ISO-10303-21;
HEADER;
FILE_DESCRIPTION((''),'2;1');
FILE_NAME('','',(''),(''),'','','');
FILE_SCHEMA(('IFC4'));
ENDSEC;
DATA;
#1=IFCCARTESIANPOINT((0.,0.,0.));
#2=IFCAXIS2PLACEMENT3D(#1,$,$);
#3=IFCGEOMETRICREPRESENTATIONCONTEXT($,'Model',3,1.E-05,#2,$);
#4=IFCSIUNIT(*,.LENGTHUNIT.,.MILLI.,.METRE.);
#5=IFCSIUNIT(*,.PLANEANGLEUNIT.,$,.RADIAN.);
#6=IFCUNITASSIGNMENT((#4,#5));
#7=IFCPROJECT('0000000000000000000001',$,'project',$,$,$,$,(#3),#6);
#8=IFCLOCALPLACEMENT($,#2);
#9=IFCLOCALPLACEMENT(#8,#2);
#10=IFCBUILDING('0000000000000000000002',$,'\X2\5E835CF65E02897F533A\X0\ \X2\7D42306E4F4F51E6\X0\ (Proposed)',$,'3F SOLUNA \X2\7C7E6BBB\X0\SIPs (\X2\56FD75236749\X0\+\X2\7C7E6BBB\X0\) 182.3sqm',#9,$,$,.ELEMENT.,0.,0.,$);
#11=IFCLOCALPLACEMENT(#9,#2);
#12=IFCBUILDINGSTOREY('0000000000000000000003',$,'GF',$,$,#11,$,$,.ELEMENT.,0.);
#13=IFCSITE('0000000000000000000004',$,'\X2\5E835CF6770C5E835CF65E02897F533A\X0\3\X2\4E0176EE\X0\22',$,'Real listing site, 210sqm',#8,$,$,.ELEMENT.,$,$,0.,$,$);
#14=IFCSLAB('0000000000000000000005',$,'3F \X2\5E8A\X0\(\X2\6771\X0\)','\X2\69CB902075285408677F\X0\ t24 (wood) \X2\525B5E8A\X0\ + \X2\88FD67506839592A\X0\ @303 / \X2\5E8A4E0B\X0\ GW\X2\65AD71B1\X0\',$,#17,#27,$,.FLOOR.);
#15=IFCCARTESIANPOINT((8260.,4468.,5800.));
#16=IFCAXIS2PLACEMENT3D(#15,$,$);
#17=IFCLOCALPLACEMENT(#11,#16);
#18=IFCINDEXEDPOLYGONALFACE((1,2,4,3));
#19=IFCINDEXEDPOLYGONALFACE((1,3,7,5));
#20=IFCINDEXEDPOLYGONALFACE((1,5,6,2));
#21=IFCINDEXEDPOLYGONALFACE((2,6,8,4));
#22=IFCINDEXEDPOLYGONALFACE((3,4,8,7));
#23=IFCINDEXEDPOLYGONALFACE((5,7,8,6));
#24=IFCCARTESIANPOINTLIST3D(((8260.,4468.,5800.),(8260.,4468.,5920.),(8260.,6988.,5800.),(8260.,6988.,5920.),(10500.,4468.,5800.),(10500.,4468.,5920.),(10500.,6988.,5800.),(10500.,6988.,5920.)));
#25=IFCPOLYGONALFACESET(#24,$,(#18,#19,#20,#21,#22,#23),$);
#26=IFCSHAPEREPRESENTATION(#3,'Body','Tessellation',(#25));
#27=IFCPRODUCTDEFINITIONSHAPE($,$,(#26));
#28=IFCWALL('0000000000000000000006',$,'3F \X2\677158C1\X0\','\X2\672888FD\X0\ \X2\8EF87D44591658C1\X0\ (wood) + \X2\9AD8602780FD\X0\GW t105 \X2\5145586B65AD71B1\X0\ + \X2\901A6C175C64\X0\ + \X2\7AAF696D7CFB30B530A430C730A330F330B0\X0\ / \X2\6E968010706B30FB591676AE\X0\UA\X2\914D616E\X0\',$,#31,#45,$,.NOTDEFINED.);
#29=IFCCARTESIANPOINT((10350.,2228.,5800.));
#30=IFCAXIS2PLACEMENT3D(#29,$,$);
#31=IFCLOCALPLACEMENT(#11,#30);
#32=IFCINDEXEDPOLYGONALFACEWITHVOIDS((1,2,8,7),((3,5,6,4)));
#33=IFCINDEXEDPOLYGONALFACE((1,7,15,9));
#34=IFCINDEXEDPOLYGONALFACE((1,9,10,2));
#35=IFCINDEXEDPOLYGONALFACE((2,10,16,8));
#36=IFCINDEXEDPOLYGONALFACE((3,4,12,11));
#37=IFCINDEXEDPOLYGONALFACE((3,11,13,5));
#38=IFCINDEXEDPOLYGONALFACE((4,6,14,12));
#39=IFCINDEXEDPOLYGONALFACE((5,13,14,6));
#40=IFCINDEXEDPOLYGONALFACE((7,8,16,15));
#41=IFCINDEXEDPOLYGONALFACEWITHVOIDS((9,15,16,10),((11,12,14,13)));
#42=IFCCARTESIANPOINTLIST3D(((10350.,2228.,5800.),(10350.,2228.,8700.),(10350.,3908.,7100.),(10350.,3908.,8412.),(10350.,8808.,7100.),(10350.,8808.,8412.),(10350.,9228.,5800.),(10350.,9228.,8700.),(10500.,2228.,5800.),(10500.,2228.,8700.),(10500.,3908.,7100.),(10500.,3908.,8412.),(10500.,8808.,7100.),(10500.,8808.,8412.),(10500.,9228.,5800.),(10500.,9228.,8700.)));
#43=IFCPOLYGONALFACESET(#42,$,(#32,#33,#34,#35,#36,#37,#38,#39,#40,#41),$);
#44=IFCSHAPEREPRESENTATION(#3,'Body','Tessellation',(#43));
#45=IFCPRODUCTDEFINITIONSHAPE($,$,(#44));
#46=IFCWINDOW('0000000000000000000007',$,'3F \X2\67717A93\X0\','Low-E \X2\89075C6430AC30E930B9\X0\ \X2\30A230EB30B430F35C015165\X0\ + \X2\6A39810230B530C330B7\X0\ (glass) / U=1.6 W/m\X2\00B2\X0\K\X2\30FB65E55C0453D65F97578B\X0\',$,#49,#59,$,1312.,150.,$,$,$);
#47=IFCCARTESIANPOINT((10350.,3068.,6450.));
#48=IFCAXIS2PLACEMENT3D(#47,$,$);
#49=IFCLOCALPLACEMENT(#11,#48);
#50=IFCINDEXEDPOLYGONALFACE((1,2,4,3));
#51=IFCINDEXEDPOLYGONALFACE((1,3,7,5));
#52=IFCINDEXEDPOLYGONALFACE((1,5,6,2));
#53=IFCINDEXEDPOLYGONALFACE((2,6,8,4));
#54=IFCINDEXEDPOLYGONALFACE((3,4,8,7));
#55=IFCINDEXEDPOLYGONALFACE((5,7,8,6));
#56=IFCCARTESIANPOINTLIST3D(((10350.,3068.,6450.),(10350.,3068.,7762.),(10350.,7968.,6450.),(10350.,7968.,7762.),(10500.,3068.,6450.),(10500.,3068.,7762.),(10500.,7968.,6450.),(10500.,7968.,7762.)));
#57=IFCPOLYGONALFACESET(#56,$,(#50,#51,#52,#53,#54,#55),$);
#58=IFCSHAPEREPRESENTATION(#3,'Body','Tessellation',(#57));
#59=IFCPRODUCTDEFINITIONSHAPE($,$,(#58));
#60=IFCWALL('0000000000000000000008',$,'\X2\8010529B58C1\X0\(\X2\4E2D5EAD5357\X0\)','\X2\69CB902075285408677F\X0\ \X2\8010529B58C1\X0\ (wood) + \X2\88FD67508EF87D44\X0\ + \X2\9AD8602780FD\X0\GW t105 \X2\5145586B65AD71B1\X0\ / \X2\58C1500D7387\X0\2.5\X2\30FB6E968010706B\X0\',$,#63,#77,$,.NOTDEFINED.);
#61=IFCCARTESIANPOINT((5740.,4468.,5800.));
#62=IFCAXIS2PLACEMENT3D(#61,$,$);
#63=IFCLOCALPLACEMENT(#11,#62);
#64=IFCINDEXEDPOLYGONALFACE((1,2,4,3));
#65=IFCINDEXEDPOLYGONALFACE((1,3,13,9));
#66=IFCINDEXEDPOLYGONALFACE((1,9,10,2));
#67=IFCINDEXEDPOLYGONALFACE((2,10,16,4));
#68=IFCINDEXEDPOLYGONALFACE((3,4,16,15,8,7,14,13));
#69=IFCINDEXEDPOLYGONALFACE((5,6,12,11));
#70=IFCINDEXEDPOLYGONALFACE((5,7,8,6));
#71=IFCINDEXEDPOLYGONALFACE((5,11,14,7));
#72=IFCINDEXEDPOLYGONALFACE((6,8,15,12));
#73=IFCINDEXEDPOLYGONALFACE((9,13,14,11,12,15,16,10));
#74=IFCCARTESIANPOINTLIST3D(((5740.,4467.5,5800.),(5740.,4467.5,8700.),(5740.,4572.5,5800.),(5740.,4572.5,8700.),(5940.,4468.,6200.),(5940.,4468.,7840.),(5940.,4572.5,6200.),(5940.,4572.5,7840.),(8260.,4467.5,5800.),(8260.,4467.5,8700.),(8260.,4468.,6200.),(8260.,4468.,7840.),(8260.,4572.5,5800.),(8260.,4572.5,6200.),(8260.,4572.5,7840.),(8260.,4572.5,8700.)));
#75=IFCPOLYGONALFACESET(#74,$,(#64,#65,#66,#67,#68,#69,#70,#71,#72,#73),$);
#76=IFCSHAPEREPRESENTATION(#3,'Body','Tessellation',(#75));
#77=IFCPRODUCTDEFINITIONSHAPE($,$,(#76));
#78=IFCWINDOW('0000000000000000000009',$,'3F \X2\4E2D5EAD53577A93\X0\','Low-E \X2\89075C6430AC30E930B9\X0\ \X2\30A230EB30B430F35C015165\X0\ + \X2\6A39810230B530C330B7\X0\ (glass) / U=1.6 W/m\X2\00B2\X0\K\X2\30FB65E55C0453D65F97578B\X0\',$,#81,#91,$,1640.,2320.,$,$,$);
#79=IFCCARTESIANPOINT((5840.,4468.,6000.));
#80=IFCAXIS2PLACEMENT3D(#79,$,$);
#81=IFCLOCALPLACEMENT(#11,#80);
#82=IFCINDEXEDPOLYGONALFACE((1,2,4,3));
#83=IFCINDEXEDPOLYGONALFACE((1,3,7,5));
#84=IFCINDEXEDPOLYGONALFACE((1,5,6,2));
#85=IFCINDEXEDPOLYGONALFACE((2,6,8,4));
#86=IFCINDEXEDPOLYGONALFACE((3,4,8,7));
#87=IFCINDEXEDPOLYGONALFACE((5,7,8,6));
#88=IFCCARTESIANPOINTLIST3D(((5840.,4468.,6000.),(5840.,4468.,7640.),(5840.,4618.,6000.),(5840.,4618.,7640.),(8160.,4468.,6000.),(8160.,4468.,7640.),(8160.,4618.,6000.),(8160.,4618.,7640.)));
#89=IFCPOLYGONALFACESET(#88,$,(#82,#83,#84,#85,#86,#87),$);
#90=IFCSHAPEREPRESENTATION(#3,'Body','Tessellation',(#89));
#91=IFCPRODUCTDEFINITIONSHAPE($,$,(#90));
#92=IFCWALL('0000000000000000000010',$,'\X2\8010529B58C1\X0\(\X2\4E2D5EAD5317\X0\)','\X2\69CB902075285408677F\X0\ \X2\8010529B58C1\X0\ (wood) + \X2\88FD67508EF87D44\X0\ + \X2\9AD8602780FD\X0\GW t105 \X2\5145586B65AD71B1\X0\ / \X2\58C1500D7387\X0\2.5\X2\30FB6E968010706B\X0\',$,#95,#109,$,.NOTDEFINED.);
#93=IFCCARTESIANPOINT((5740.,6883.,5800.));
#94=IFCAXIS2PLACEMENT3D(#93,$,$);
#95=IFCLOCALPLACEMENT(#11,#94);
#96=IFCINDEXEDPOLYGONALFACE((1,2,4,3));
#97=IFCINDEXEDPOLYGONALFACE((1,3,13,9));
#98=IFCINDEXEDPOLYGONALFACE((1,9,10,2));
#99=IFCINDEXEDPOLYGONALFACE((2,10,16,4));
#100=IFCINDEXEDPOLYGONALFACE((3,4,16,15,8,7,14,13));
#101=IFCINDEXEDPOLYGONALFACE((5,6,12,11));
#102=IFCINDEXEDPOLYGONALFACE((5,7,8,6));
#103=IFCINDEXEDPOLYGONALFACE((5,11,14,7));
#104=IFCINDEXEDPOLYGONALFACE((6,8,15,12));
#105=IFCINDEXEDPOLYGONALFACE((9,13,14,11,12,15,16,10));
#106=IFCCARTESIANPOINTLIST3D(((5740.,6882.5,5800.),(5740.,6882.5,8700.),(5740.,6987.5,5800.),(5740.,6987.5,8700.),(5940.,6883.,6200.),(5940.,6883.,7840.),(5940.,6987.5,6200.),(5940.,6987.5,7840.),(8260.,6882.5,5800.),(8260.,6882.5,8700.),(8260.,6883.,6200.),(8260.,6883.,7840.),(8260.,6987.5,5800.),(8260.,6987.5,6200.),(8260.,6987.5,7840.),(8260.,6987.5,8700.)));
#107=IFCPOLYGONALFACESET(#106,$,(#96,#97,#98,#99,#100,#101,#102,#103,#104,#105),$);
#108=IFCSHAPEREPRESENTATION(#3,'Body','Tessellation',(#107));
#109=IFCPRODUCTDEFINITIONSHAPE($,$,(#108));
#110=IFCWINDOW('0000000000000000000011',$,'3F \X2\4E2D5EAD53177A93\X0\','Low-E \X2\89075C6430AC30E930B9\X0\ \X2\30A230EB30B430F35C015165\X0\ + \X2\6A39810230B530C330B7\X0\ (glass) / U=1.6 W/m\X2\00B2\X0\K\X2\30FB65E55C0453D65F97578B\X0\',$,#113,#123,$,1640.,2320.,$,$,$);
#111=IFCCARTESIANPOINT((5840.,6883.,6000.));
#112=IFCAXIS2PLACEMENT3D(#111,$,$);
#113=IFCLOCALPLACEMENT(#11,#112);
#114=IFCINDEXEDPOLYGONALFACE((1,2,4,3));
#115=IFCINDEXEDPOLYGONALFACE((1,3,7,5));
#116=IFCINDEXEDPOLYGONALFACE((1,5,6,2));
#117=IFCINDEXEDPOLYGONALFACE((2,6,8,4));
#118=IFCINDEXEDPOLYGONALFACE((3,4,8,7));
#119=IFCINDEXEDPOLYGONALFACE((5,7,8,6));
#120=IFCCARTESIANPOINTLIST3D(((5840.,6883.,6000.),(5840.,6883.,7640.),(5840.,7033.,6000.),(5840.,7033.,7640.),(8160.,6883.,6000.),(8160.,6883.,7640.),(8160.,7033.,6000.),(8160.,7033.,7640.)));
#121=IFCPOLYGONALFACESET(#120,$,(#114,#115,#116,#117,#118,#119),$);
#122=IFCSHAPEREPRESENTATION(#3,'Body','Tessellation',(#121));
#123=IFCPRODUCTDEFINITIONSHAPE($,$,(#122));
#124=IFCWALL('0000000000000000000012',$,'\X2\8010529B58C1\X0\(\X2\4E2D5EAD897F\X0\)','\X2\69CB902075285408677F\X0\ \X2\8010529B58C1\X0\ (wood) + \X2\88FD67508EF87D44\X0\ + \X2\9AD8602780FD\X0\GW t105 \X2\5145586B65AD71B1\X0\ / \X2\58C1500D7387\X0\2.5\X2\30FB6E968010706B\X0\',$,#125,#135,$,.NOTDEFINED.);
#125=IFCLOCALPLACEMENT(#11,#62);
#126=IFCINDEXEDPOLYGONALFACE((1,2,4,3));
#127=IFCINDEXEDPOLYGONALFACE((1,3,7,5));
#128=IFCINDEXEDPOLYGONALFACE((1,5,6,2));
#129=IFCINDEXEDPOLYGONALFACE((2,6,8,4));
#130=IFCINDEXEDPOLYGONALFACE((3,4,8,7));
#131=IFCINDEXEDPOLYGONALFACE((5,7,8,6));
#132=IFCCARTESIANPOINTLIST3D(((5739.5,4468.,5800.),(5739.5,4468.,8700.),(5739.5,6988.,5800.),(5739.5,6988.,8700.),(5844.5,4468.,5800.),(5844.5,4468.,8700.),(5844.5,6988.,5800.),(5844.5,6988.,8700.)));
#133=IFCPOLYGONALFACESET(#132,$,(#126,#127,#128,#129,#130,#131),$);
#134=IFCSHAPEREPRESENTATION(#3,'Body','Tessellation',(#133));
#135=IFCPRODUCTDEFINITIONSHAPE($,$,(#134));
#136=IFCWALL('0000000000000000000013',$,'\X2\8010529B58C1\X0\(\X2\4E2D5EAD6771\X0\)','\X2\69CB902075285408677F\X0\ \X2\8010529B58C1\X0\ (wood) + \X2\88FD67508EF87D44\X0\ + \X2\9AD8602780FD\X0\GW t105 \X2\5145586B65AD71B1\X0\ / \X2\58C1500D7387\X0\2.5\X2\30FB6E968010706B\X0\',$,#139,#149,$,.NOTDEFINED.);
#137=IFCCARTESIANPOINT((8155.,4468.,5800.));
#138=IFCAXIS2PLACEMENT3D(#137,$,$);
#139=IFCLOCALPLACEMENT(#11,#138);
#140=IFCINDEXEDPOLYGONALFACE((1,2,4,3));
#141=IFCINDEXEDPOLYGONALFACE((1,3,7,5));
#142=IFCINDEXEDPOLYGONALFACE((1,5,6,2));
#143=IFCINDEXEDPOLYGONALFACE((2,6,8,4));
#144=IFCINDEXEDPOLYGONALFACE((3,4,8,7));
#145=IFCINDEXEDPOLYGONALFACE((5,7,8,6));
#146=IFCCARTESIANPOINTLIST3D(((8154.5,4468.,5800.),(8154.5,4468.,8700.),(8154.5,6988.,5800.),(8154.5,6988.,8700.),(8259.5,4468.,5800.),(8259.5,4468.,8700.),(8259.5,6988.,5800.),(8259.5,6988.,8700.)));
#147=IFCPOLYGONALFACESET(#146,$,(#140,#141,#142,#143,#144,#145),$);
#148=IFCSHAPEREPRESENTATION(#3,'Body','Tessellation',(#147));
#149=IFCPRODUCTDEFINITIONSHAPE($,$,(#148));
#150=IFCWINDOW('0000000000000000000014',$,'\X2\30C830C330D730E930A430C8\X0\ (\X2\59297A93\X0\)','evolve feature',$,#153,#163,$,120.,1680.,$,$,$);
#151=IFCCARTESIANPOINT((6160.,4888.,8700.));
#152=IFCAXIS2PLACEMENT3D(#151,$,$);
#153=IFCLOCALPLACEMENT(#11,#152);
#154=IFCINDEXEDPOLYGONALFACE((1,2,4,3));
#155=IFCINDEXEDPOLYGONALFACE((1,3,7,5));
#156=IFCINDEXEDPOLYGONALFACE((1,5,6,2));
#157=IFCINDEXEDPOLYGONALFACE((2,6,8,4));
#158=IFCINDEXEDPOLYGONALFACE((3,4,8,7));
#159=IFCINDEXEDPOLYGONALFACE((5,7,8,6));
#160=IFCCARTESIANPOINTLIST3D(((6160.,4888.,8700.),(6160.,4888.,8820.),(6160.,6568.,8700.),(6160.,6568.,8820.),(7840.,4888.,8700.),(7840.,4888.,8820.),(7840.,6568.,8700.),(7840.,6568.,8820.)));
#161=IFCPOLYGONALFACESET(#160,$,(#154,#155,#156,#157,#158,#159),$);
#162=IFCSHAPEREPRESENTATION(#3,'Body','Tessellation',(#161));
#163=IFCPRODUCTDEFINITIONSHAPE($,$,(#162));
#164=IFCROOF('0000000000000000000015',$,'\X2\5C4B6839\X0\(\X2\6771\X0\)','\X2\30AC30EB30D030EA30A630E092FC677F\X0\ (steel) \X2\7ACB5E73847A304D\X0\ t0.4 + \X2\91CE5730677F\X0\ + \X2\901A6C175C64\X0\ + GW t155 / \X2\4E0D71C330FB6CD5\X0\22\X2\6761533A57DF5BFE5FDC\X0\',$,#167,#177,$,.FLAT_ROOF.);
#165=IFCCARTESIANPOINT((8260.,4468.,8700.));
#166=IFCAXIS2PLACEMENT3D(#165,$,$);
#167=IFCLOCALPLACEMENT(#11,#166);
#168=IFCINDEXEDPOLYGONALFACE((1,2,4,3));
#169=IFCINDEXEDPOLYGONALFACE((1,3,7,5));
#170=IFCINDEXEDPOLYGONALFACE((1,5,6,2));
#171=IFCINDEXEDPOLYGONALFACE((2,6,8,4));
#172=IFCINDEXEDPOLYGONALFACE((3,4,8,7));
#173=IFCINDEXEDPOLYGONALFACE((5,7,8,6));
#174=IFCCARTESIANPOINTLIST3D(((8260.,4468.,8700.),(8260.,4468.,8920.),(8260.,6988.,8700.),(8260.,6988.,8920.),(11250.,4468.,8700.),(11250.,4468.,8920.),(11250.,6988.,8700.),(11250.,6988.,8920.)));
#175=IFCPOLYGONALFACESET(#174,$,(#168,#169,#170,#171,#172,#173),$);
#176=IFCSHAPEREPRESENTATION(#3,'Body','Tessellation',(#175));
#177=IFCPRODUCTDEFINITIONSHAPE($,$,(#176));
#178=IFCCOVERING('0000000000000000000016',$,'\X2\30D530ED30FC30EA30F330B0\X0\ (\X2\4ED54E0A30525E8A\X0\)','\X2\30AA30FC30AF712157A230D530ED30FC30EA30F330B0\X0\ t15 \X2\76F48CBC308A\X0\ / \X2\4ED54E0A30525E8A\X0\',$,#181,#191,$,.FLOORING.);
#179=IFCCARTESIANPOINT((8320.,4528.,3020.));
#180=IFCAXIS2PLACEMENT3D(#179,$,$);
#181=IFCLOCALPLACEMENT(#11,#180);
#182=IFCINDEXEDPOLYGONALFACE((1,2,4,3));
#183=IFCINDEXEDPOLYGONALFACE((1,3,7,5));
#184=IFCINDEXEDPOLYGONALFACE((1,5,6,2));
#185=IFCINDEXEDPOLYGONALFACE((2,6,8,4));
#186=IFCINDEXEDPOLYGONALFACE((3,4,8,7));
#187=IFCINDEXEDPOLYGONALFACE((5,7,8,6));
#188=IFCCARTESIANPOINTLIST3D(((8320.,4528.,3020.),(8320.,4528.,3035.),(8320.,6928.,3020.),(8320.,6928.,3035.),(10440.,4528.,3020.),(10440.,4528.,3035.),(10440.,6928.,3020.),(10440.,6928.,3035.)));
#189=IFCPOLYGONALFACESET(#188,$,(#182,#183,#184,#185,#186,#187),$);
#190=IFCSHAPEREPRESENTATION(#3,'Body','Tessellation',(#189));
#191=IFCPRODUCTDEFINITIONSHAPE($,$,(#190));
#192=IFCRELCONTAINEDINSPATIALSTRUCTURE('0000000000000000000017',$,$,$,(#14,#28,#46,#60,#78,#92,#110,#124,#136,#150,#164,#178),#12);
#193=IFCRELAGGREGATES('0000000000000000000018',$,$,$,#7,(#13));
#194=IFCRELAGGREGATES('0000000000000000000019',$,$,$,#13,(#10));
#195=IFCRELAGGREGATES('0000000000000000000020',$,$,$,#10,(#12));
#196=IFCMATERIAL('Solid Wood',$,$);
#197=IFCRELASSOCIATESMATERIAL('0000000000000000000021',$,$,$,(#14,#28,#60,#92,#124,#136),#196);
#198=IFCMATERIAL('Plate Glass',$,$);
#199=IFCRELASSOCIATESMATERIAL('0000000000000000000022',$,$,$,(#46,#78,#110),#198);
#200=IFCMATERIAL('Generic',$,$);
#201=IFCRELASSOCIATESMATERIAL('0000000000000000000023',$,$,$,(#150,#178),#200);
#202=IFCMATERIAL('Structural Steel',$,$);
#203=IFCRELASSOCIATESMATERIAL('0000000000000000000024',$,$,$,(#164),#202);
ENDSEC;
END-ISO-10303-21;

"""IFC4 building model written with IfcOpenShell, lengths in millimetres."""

from ifc_helpers import new_model, si_unit, frame, frame_2d, origin, place, context, project, spatial, rectangle, extrude, material, element, fill, save


model = new_model("IFC4")

# Units and contexts
model_context = context("Model", 3, precision=1e-05, world=origin())
ifc_project = project(units=[si_unit("LENGTHUNIT", "METRE", prefix="MILLI"), si_unit("PLANEANGLEUNIT", "RADIAN")], contexts=[model_context])

# Site, building, storey
site_placement = place(None, origin())
site = spatial("IfcSite", under=ifc_project, at=site_placement, Name="広島県広島市西区3丁目22", ObjectType="Real listing site, 210sqm", CompositionType="ELEMENT", RefElevation=0.0)
building_placement = place(site_placement, origin())
building = spatial("IfcBuilding", under=site, at=building_placement, Name="広島市西区 終の住処 (Proposed)", ObjectType="3F SOLUNA 籾殻SIPs (国産杉+籾殻) 182.3sqm", CompositionType="ELEMENT", ElevationOfRefHeight=0.0, ElevationOfTerrain=0.0)
storey_placement = place(building_placement, origin())
storey = spatial("IfcBuildingStorey", under=building, at=storey_placement, Name="GF", CompositionType="ELEMENT", Elevation=0.0)

# Slab
ifc_material_1 = material(Name="Solid Wood")
slab_placement = place(storey_placement, frame((8260.0, 4468.0, 5800.0)))
element("IfcSlab", 1, at=slab_placement, inside=storey, material=ifc_material_1, Name="3F 床(東)", Description="構造用合板 t24 (wood) 剛床 + 製材根太 @303 / 床下 GW断熱", PredefinedType="FLOOR", context=model_context, shape_type="SweptSolid", body=[
    extrude(rectangle(XDim=2240.0, YDim=2520.0, at=frame_2d((1120.0, 1260.0))), frame((8260.0, 4468.0, 5800.0)), (0.0, 0.0, 1.0), 120.0),
])

# Walls, openings, windows
wall_1_placement = place(storey_placement, frame((10350.0, 2228.0, 5800.0)))
wall_1 = element("IfcWall", 2, at=wall_1_placement, inside=storey, material=ifc_material_1, Name="3F 東壁", Description="木製 軸組外壁 (wood) + 高性能GW t105 充填断熱 + 通気層 + 窯業系サイディング / 準耐火・外皮UA配慮", PredefinedType="NOTDEFINED", context=model_context, shape_type="SweptSolid", body=[
    extrude(rectangle(XDim=150.0, YDim=7000.0, at=frame_2d((75.0, 3500.0))), frame((10350.0, 2228.0, 5800.0)), (0.0, 0.0, 1.0), 2900.0),
])
opening_1_placement = place(storey_placement, frame((10350.0, 3068.0, 6450.0)))
opening_1 = element("IfcOpeningElement", 3, at=opening_1_placement, cuts=wall_1, PredefinedType="NOTDEFINED", context=model_context, shape_type="SweptSolid", body=[
    extrude(rectangle(XDim=150.0, YDim=4900.0, at=frame_2d((75.0, 2450.0))), frame((10350.0, 3068.0, 6450.0)), (0.0, 0.0, 1.0), 1312.0),
])
ifc_material_2 = material(Name="Plate Glass")
window_1_placement = place(storey_placement, frame((10350.0, 3068.0, 6450.0)))
window_1 = element("IfcWindow", 4, at=window_1_placement, inside=storey, material=ifc_material_2, Name="3F 東窓", Description="Low-E 複層ガラス アルゴン封入 + 樹脂サッシ (glass) / U=1.6 W/m²K・日射取得型", OverallHeight=1312.0, OverallWidth=150.0, context=model_context, shape_type="SweptSolid", body=[
    extrude(rectangle(XDim=150.0, YDim=4900.0, at=frame_2d((75.0, 2450.0))), frame((10350.0, 3068.0, 6450.0)), (0.0, 0.0, 1.0), 1312.0),
])
fill(opening_1, window_1)
wall_2_placement = place(storey_placement, frame((5740.0, 4468.0, 5800.0)))
wall_2 = element("IfcWall", 5, at=wall_2_placement, inside=storey, material=ifc_material_1, Name="耐力壁(中庭南)", Description="構造用合板 耐力壁 (wood) + 製材軸組 + 高性能GW t105 充填断熱 / 壁倍率2.5・準耐火", PredefinedType="NOTDEFINED", context=model_context, shape_type="SweptSolid", body=[
    extrude(rectangle(XDim=2520.0, YDim=105.0, at=frame_2d((1260.0, 52.0))), frame((5740.0, 4468.0, 5800.0)), (0.0, 0.0, 1.0), 2900.0),
])
opening_2_placement = place(storey_placement, frame((5840.0, 4468.0, 6000.0)))
opening_2 = element("IfcOpeningElement", 6, at=opening_2_placement, cuts=wall_2, PredefinedType="NOTDEFINED", context=model_context, shape_type="SweptSolid", body=[
    extrude(rectangle(XDim=2320.0, YDim=150.0, at=frame_2d((1160.0, 75.0))), frame((5840.0, 4468.0, 6000.0)), (0.0, 0.0, 1.0), 1640.0),
])
window_2_placement = place(storey_placement, frame((5840.0, 4468.0, 6000.0)))
window_2 = element("IfcWindow", 7, at=window_2_placement, inside=storey, material=ifc_material_2, Name="3F 中庭南窓", Description="Low-E 複層ガラス アルゴン封入 + 樹脂サッシ (glass) / U=1.6 W/m²K・日射取得型", OverallHeight=1640.0, OverallWidth=2320.0, context=model_context, shape_type="SweptSolid", body=[
    extrude(rectangle(XDim=2320.0, YDim=150.0, at=frame_2d((1160.0, 75.0))), frame((5840.0, 4468.0, 6000.0)), (0.0, 0.0, 1.0), 1640.0),
])
fill(opening_2, window_2)
wall_3_placement = place(storey_placement, frame((5740.0, 6883.0, 5800.0)))
wall_3 = element("IfcWall", 8, at=wall_3_placement, inside=storey, material=ifc_material_1, Name="耐力壁(中庭北)", Description="構造用合板 耐力壁 (wood) + 製材軸組 + 高性能GW t105 充填断熱 / 壁倍率2.5・準耐火", PredefinedType="NOTDEFINED", context=model_context, shape_type="SweptSolid", body=[
    extrude(rectangle(XDim=2520.0, YDim=105.0, at=frame_2d((1260.0, 52.0))), frame((5740.0, 6883.0, 5800.0)), (0.0, 0.0, 1.0), 2900.0),
])
opening_3_placement = place(storey_placement, frame((5840.0, 6883.0, 6000.0)))
opening_3 = element("IfcOpeningElement", 9, at=opening_3_placement, cuts=wall_3, PredefinedType="NOTDEFINED", context=model_context, shape_type="SweptSolid", body=[
    extrude(rectangle(XDim=2320.0, YDim=150.0, at=frame_2d((1160.0, 75.0))), frame((5840.0, 6883.0, 6000.0)), (0.0, 0.0, 1.0), 1640.0),
])
window_3_placement = place(storey_placement, frame((5840.0, 6883.0, 6000.0)))
window_3 = element("IfcWindow", 10, at=window_3_placement, inside=storey, material=ifc_material_2, Name="3F 中庭北窓", Description="Low-E 複層ガラス アルゴン封入 + 樹脂サッシ (glass) / U=1.6 W/m²K・日射取得型", OverallHeight=1640.0, OverallWidth=2320.0, context=model_context, shape_type="SweptSolid", body=[
    extrude(rectangle(XDim=2320.0, YDim=150.0, at=frame_2d((1160.0, 75.0))), frame((5840.0, 6883.0, 6000.0)), (0.0, 0.0, 1.0), 1640.0),
])
fill(opening_3, window_3)

# Walls
wall_4_placement = place(storey_placement, frame((5740.0, 4468.0, 5800.0)))
element("IfcWall", 11, at=wall_4_placement, inside=storey, material=ifc_material_1, Name="耐力壁(中庭西)", Description="構造用合板 耐力壁 (wood) + 製材軸組 + 高性能GW t105 充填断熱 / 壁倍率2.5・準耐火", PredefinedType="NOTDEFINED", context=model_context, shape_type="SweptSolid", body=[
    extrude(rectangle(XDim=105.0, YDim=2520.0, at=frame_2d((52.0, 1260.0))), frame((5740.0, 4468.0, 5800.0)), (0.0, 0.0, 1.0), 2900.0),
])
wall_5_placement = place(storey_placement, frame((8155.0, 4468.0, 5800.0)))
element("IfcWall", 12, at=wall_5_placement, inside=storey, material=ifc_material_1, Name="耐力壁(中庭東)", Description="構造用合板 耐力壁 (wood) + 製材軸組 + 高性能GW t105 充填断熱 / 壁倍率2.5・準耐火", PredefinedType="NOTDEFINED", context=model_context, shape_type="SweptSolid", body=[
    extrude(rectangle(XDim=105.0, YDim=2520.0, at=frame_2d((52.0, 1260.0))), frame((8155.0, 4468.0, 5800.0)), (0.0, 0.0, 1.0), 2900.0),
])

# Window
ifc_material_3 = material(Name="Generic")
window_4_placement = place(storey_placement, frame((6160.0, 4888.0, 8700.0)))
element("IfcWindow", 13, at=window_4_placement, inside=storey, material=ifc_material_3, Name="トップライト (天窓)", Description="evolve feature", OverallHeight=120.0, OverallWidth=1680.0, context=model_context, shape_type="SweptSolid", body=[
    extrude(rectangle(XDim=1680.0, YDim=1680.0, at=frame_2d((840.0, 840.0))), frame((6160.0, 4888.0, 8700.0)), (0.0, 0.0, 1.0), 120.0),
])

# Roof
ifc_material_4 = material(Name="Structural Steel")
for number, where, name in (
    (14, (8260.0, 4468.0, 8700.0), "屋根(東)"),
):
    element("IfcRoof", number, at=place(storey_placement, frame(where)), inside=storey, material=ifc_material_4, Name=name, Description="ガルバリウム鋼板 (steel) 立平葺き t0.4 + 野地板 + 通気層 + GW t155 / 不燃・法22条区域対応", PredefinedType="FLAT_ROOF", context=model_context, shape_type="SweptSolid", body=[
        extrude(rectangle(XDim=2990.0, YDim=2520.0, at=frame_2d((1495.0, 1260.0))), frame((8260.0, 4468.0, 8700.0)), (0.0, 0.0, 1.0), 220.0),
    ])

# Covering
covering_1_placement = place(storey_placement, frame((8320.0, 4528.0, 3020.0)))
element("IfcCovering", 15, at=covering_1_placement, inside=storey, material=ifc_material_3, Name="フローリング (仕上げ床)", Description="オーク無垢フローリング t15 直貼り / 仕上げ床", PredefinedType="FLOORING", context=model_context, shape_type="SweptSolid", body=[
    extrude(rectangle(XDim=2120.0, YDim=2400.0, at=frame_2d((1060.0, 1200.0))), frame((8320.0, 4528.0, 3020.0)), (0.0, 0.0, 1.0), 15.0),
])

save(model, "model.ifc")
